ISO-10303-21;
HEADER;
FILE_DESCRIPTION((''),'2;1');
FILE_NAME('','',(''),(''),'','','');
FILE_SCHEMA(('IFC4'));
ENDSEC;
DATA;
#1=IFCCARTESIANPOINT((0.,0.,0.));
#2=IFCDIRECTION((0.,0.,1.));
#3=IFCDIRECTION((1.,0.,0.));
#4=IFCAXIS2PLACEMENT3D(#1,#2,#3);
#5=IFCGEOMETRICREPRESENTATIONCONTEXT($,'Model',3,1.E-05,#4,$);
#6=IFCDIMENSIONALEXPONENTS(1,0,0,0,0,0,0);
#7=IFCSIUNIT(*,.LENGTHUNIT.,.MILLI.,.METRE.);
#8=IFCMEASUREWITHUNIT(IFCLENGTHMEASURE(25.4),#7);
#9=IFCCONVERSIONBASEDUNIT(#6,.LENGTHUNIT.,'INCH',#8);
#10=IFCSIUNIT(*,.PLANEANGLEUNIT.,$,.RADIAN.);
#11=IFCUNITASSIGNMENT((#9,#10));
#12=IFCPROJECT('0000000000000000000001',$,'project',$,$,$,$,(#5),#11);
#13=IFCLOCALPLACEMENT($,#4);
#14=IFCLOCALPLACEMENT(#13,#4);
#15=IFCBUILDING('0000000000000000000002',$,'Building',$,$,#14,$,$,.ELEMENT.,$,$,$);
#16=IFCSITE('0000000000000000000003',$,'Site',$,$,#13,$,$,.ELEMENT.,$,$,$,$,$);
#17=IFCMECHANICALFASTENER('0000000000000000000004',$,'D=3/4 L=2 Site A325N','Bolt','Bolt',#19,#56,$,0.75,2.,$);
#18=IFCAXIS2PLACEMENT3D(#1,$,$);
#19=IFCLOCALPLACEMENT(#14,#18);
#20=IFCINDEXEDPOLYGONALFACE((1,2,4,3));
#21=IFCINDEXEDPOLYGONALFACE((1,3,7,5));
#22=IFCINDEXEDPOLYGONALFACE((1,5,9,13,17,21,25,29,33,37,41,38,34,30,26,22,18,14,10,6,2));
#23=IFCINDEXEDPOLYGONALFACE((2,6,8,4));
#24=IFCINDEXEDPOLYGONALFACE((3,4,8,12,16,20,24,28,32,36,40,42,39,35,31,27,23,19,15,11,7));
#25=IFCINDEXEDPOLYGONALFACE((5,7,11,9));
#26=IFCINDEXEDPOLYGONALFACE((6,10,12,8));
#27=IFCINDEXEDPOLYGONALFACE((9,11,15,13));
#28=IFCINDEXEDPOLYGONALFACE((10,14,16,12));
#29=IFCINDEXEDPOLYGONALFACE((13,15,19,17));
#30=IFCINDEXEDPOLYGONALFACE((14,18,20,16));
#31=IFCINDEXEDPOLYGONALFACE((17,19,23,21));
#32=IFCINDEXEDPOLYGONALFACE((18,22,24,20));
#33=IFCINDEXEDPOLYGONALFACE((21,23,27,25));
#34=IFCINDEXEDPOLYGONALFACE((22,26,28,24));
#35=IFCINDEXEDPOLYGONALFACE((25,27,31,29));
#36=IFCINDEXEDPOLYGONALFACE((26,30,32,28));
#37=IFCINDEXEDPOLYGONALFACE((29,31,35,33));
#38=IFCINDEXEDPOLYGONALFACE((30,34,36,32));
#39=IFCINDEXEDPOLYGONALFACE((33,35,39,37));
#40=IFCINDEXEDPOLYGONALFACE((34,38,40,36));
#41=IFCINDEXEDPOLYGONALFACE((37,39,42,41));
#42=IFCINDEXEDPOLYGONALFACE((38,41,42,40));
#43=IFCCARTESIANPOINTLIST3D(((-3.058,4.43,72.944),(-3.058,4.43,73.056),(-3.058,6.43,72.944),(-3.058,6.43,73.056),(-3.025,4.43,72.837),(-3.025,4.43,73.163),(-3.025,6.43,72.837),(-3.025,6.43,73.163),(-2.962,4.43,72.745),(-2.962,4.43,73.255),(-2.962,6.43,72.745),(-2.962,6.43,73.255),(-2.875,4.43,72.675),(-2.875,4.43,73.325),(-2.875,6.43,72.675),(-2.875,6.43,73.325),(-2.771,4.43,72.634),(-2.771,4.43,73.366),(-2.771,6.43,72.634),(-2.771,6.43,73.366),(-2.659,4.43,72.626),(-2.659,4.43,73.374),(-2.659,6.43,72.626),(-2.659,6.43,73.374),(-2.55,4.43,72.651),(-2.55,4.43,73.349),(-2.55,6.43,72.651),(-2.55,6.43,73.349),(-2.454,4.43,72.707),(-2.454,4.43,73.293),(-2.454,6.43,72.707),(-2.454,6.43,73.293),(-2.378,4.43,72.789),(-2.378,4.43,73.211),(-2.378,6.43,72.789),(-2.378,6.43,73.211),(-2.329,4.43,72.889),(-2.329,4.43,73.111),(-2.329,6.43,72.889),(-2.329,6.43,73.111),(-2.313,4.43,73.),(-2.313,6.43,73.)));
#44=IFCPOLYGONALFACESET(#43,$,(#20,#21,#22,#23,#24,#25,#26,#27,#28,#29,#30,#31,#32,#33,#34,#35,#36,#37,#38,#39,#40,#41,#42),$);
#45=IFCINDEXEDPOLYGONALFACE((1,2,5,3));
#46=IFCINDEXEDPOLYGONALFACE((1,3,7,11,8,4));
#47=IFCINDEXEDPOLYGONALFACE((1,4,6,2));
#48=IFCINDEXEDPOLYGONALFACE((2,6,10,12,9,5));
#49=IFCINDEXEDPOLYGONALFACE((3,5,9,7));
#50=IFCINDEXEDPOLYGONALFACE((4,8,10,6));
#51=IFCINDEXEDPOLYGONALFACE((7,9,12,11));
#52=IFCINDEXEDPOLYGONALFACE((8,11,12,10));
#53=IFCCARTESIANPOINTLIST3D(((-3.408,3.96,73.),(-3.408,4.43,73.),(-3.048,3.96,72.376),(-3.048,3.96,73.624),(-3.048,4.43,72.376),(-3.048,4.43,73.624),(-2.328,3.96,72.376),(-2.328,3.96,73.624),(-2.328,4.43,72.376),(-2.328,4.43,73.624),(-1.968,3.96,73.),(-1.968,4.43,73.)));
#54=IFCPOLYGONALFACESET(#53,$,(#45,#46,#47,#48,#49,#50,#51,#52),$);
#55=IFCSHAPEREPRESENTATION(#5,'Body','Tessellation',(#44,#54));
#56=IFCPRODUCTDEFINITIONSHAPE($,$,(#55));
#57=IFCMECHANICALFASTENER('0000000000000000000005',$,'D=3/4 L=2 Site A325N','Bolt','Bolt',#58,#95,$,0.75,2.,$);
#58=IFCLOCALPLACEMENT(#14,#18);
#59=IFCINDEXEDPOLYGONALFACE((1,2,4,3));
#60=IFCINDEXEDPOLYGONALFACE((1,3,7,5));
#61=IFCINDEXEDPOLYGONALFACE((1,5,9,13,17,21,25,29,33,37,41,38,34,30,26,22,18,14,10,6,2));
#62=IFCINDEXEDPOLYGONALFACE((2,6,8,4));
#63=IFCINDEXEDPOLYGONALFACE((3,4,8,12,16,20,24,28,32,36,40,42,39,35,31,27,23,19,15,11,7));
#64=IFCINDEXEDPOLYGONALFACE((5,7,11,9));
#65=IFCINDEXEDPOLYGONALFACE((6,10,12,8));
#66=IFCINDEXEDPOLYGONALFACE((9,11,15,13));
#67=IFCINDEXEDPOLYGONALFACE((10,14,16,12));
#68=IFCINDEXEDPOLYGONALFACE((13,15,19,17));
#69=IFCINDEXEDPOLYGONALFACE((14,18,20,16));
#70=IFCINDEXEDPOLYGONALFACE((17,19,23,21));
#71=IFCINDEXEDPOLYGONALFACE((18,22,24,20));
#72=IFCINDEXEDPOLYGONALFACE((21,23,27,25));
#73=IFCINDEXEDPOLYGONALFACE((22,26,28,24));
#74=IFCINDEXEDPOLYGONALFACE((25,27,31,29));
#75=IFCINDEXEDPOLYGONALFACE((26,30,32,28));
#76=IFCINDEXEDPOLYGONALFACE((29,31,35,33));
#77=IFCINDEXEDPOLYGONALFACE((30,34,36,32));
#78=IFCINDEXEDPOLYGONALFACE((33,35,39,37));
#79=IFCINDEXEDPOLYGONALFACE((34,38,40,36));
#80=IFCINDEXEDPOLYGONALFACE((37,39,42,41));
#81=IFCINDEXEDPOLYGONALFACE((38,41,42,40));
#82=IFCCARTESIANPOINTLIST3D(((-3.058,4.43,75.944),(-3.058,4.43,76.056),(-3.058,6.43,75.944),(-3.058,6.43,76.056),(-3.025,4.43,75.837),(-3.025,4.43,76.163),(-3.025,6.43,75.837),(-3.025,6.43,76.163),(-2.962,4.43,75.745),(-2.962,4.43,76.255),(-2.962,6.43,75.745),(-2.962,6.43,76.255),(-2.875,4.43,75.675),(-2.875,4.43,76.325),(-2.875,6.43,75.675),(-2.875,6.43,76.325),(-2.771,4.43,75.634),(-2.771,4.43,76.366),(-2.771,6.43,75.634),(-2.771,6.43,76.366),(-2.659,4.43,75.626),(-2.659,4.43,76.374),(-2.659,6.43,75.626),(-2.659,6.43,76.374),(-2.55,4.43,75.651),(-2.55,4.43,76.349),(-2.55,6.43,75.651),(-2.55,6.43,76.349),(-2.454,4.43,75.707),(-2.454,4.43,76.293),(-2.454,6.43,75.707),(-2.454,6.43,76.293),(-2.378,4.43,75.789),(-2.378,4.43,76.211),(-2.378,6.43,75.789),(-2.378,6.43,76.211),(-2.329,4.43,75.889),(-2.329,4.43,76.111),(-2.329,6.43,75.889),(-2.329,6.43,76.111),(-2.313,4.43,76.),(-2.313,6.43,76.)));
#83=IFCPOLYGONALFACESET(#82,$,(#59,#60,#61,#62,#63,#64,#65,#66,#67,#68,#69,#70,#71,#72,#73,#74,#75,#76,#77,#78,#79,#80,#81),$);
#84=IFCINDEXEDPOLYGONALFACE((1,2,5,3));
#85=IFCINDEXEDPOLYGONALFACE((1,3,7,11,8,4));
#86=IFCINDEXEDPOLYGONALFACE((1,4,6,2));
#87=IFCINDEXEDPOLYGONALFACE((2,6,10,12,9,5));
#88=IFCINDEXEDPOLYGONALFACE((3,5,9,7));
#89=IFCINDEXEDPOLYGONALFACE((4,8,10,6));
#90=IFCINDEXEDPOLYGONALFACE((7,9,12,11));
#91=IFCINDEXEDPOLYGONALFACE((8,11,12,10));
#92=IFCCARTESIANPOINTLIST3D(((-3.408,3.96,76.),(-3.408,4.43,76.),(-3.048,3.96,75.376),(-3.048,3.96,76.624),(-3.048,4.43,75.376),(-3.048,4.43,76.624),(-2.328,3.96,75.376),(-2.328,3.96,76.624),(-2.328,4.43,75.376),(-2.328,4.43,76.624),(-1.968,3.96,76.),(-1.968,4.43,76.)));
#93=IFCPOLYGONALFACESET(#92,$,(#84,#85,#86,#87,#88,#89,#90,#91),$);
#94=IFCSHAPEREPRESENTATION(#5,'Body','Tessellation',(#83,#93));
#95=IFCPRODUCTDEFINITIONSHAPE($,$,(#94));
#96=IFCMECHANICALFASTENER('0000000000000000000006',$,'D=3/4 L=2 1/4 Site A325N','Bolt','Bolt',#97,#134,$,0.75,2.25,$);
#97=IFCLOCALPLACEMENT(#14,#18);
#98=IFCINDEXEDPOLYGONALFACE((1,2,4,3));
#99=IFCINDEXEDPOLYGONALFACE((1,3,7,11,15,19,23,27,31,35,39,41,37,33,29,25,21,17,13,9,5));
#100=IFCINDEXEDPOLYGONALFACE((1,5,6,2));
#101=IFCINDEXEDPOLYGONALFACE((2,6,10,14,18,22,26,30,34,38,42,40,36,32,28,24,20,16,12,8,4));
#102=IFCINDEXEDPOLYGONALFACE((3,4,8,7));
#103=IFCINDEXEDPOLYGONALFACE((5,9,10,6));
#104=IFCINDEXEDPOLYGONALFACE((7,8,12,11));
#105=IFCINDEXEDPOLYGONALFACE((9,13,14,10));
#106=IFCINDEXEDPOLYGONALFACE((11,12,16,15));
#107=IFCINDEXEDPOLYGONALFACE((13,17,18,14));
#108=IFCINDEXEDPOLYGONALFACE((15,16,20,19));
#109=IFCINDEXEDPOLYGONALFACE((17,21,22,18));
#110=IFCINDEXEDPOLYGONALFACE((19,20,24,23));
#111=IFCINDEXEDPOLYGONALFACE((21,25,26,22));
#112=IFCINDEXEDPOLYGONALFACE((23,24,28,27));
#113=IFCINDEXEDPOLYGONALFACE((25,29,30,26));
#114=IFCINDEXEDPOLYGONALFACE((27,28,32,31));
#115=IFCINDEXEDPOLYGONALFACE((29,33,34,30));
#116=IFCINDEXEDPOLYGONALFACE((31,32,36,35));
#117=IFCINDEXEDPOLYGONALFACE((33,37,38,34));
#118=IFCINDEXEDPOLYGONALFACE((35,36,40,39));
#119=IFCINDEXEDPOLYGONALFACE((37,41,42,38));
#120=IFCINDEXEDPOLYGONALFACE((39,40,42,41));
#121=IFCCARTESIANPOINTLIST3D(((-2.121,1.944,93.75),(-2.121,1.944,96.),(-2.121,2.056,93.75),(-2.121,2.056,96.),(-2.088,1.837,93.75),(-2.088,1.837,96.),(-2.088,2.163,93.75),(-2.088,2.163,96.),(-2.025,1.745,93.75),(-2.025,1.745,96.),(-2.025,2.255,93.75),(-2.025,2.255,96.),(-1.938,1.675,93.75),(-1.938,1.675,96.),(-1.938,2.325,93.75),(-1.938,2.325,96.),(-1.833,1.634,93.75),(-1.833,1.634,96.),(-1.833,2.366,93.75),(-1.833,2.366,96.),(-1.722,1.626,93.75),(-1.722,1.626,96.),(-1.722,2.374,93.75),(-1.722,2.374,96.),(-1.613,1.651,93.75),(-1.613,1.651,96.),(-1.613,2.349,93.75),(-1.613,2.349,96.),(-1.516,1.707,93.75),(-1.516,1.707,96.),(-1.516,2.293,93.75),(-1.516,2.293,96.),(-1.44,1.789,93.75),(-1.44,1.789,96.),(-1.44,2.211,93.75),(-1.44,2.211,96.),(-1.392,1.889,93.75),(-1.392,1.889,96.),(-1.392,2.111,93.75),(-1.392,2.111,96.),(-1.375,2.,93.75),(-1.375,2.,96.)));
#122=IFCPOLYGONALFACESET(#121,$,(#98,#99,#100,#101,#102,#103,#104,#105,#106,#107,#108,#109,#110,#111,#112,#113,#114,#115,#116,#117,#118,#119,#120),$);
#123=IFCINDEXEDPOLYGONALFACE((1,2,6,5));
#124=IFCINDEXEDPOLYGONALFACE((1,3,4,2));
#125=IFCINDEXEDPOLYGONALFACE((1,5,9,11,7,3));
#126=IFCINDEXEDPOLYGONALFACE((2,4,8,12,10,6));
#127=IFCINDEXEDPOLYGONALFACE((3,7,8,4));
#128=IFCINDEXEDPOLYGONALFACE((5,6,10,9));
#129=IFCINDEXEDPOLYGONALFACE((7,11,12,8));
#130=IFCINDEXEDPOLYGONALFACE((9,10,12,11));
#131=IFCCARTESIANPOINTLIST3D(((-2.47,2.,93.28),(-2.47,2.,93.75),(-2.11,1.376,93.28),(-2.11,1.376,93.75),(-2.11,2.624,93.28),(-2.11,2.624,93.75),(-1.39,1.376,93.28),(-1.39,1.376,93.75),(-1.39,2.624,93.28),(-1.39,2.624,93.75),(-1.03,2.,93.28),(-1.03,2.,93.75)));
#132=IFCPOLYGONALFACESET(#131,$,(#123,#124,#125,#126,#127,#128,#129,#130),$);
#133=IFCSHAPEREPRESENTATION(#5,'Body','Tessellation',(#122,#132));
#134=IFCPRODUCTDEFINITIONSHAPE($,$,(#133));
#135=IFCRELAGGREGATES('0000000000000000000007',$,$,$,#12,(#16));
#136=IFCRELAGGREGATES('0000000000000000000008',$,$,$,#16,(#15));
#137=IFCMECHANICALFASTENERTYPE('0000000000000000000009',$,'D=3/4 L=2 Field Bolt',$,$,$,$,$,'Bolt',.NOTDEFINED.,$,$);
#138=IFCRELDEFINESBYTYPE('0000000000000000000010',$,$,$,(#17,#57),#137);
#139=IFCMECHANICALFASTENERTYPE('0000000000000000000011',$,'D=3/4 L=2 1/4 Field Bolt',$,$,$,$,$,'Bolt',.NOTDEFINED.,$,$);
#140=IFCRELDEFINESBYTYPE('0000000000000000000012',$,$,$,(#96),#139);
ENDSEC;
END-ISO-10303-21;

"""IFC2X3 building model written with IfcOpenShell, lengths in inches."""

from ifc_helpers import new_model, entity, si_unit, converted_unit, frame, origin_with_axes, origin_2d_with_axis, place, context, project, spatial, polyline, circle, outline, extrude, source, transform, mapped, type_object, type_shapes, element, save


model = new_model("IFC2X3")

# Units and contexts
model_context = context("Model", 3, precision=1e-05, world=origin_with_axes())
ifc_project = project(units=[converted_unit("LENGTHUNIT", "INCH", entity("IfcLengthMeasure", 25.4), si_unit("LENGTHUNIT", "METRE", prefix="MILLI"), dimensions=[1, 0, 0, 0, 0, 0, 0]), si_unit("PLANEANGLEUNIT", "RADIAN")], contexts=[model_context])

# Site, building
site_placement = place(None, origin_with_axes())
site = spatial("IfcSite", under=ifc_project, at=site_placement, Name="Site", CompositionType="ELEMENT")
building_placement = place(site_placement, origin_with_axes())
building = spatial("IfcBuilding", under=site, at=building_placement, Name="Building", CompositionType="ELEMENT")

# Shared definitions
assembly_1_placement = place(building_placement, frame((0.0, 0.0, 54.5), z_axis=(0.0, -1.0, 0.0), x_axis=(0.0, 0.0, 1.0)))
assembly_2_placement = place(building_placement, frame((0.0, 0.0, 80.0), z_axis=(0.0, 0.0, 1.0), x_axis=(0.0, 1.0, 0.0)))

# Mechanical fasteners
mechanical_fastener_type_1 = type_object("IfcMechanicalFastenerType", Name="D=3/4 L=2 Field Bolt", ElementType="Bolt")
shared_shape_1 = source(origin_with_axes(), model_context, "Body", "SweptSolid", [
    extrude(circle(Radius=0.375, at=origin_2d_with_axis()), frame((0.0, 0.0, 0.0), z_axis=(1.0, 0.0, 0.0), x_axis=(0.0, 1.0, 0.0)), (0.0, 0.0, 1.0), 2.0),
    extrude(outline(polyline([(-0.72, 0.0), (-0.36, 0.624), (0.36, 0.624), (0.72, 0.0), (0.36, -0.624), (-0.36, -0.624), (-0.72, 0.0)])), frame((0.0, 0.0, 0.0), z_axis=(1.0, 0.0, 0.0), x_axis=(0.0, 1.0, 0.0)), (0.0, 0.0, -1.0), 0.47),
])
type_shapes(mechanical_fastener_type_1, [shared_shape_1])
placement_1 = place(assembly_2_placement, frame((4.43, 2.688, -4.0), z_axis=(0.0, 0.0, -1.0), x_axis=(1.0, 0.0, 0.0)))
for number, where, z_axis, x_axis, name in (
    (1, (0.0, 0.0, 3.0), (0.0, 0.0, 1.0), (1.0, 0.0, 0.0), "D=3/4 L=2 Site A325N"),
    (2, (0.0, 0.0, 0.0), (0.0, 0.0, 1.0), (1.0, 0.0, 0.0), "D=3/4 L=2 Site A325N"),
):
    element("IfcMechanicalFastener", number, at=place(placement_1, frame(where, z_axis=z_axis, x_axis=x_axis)), type_object=mechanical_fastener_type_1, Name=name, Description="Bolt", ObjectType="Bolt", NominalDiameter=0.75, NominalLength=2.0, context=model_context, shape_type="MappedRepresentation", body=[
        mapped(shared_shape_1, transform((0.0, 0.0, 0.0), scale=1.0)),
    ])
mechanical_fastener_type_2 = type_object("IfcMechanicalFastenerType", Name="D=3/4 L=2 1/4 Field Bolt", ElementType="Bolt")
shared_shape_2 = source(origin_with_axes(), model_context, "Body", "SweptSolid", [
    extrude(circle(Radius=0.375, at=origin_2d_with_axis()), frame((0.0, 0.0, 0.0), z_axis=(1.0, 0.0, 0.0), x_axis=(0.0, 1.0, 0.0)), (0.0, 0.0, 1.0), 2.25),
    extrude(outline(polyline([(-0.72, 0.0), (-0.36, 0.624), (0.36, 0.624), (0.72, 0.0), (0.36, -0.624), (-0.36, -0.624), (-0.72, 0.0)])), frame((0.0, 0.0, 0.0), z_axis=(1.0, 0.0, 0.0), x_axis=(0.0, 1.0, 0.0)), (0.0, 0.0, -1.0), 0.47),
])
type_shapes(mechanical_fastener_type_2, [shared_shape_2])
placement_2 = place(assembly_1_placement, frame((39.25, -1.75, -2.0), z_axis=(0.0, 0.0, -1.0), x_axis=(1.0, 0.0, 0.0)))
mechanical_fastener_1_placement = place(placement_2, frame((0.0, -3.5, 0.0), z_axis=(0.0, 0.0, 1.0), x_axis=(1.0, 0.0, 0.0)))
element("IfcMechanicalFastener", 3, at=mechanical_fastener_1_placement, type_object=mechanical_fastener_type_2, Name="D=3/4 L=2 1/4 Site A325N", Description="Bolt", ObjectType="Bolt", NominalDiameter=0.75, NominalLength=2.25, context=model_context, shape_type="MappedRepresentation", body=[
    mapped(shared_shape_2, transform((0.0, 0.0, 0.0), scale=1.0)),
])

save(model, "model.ifc")
